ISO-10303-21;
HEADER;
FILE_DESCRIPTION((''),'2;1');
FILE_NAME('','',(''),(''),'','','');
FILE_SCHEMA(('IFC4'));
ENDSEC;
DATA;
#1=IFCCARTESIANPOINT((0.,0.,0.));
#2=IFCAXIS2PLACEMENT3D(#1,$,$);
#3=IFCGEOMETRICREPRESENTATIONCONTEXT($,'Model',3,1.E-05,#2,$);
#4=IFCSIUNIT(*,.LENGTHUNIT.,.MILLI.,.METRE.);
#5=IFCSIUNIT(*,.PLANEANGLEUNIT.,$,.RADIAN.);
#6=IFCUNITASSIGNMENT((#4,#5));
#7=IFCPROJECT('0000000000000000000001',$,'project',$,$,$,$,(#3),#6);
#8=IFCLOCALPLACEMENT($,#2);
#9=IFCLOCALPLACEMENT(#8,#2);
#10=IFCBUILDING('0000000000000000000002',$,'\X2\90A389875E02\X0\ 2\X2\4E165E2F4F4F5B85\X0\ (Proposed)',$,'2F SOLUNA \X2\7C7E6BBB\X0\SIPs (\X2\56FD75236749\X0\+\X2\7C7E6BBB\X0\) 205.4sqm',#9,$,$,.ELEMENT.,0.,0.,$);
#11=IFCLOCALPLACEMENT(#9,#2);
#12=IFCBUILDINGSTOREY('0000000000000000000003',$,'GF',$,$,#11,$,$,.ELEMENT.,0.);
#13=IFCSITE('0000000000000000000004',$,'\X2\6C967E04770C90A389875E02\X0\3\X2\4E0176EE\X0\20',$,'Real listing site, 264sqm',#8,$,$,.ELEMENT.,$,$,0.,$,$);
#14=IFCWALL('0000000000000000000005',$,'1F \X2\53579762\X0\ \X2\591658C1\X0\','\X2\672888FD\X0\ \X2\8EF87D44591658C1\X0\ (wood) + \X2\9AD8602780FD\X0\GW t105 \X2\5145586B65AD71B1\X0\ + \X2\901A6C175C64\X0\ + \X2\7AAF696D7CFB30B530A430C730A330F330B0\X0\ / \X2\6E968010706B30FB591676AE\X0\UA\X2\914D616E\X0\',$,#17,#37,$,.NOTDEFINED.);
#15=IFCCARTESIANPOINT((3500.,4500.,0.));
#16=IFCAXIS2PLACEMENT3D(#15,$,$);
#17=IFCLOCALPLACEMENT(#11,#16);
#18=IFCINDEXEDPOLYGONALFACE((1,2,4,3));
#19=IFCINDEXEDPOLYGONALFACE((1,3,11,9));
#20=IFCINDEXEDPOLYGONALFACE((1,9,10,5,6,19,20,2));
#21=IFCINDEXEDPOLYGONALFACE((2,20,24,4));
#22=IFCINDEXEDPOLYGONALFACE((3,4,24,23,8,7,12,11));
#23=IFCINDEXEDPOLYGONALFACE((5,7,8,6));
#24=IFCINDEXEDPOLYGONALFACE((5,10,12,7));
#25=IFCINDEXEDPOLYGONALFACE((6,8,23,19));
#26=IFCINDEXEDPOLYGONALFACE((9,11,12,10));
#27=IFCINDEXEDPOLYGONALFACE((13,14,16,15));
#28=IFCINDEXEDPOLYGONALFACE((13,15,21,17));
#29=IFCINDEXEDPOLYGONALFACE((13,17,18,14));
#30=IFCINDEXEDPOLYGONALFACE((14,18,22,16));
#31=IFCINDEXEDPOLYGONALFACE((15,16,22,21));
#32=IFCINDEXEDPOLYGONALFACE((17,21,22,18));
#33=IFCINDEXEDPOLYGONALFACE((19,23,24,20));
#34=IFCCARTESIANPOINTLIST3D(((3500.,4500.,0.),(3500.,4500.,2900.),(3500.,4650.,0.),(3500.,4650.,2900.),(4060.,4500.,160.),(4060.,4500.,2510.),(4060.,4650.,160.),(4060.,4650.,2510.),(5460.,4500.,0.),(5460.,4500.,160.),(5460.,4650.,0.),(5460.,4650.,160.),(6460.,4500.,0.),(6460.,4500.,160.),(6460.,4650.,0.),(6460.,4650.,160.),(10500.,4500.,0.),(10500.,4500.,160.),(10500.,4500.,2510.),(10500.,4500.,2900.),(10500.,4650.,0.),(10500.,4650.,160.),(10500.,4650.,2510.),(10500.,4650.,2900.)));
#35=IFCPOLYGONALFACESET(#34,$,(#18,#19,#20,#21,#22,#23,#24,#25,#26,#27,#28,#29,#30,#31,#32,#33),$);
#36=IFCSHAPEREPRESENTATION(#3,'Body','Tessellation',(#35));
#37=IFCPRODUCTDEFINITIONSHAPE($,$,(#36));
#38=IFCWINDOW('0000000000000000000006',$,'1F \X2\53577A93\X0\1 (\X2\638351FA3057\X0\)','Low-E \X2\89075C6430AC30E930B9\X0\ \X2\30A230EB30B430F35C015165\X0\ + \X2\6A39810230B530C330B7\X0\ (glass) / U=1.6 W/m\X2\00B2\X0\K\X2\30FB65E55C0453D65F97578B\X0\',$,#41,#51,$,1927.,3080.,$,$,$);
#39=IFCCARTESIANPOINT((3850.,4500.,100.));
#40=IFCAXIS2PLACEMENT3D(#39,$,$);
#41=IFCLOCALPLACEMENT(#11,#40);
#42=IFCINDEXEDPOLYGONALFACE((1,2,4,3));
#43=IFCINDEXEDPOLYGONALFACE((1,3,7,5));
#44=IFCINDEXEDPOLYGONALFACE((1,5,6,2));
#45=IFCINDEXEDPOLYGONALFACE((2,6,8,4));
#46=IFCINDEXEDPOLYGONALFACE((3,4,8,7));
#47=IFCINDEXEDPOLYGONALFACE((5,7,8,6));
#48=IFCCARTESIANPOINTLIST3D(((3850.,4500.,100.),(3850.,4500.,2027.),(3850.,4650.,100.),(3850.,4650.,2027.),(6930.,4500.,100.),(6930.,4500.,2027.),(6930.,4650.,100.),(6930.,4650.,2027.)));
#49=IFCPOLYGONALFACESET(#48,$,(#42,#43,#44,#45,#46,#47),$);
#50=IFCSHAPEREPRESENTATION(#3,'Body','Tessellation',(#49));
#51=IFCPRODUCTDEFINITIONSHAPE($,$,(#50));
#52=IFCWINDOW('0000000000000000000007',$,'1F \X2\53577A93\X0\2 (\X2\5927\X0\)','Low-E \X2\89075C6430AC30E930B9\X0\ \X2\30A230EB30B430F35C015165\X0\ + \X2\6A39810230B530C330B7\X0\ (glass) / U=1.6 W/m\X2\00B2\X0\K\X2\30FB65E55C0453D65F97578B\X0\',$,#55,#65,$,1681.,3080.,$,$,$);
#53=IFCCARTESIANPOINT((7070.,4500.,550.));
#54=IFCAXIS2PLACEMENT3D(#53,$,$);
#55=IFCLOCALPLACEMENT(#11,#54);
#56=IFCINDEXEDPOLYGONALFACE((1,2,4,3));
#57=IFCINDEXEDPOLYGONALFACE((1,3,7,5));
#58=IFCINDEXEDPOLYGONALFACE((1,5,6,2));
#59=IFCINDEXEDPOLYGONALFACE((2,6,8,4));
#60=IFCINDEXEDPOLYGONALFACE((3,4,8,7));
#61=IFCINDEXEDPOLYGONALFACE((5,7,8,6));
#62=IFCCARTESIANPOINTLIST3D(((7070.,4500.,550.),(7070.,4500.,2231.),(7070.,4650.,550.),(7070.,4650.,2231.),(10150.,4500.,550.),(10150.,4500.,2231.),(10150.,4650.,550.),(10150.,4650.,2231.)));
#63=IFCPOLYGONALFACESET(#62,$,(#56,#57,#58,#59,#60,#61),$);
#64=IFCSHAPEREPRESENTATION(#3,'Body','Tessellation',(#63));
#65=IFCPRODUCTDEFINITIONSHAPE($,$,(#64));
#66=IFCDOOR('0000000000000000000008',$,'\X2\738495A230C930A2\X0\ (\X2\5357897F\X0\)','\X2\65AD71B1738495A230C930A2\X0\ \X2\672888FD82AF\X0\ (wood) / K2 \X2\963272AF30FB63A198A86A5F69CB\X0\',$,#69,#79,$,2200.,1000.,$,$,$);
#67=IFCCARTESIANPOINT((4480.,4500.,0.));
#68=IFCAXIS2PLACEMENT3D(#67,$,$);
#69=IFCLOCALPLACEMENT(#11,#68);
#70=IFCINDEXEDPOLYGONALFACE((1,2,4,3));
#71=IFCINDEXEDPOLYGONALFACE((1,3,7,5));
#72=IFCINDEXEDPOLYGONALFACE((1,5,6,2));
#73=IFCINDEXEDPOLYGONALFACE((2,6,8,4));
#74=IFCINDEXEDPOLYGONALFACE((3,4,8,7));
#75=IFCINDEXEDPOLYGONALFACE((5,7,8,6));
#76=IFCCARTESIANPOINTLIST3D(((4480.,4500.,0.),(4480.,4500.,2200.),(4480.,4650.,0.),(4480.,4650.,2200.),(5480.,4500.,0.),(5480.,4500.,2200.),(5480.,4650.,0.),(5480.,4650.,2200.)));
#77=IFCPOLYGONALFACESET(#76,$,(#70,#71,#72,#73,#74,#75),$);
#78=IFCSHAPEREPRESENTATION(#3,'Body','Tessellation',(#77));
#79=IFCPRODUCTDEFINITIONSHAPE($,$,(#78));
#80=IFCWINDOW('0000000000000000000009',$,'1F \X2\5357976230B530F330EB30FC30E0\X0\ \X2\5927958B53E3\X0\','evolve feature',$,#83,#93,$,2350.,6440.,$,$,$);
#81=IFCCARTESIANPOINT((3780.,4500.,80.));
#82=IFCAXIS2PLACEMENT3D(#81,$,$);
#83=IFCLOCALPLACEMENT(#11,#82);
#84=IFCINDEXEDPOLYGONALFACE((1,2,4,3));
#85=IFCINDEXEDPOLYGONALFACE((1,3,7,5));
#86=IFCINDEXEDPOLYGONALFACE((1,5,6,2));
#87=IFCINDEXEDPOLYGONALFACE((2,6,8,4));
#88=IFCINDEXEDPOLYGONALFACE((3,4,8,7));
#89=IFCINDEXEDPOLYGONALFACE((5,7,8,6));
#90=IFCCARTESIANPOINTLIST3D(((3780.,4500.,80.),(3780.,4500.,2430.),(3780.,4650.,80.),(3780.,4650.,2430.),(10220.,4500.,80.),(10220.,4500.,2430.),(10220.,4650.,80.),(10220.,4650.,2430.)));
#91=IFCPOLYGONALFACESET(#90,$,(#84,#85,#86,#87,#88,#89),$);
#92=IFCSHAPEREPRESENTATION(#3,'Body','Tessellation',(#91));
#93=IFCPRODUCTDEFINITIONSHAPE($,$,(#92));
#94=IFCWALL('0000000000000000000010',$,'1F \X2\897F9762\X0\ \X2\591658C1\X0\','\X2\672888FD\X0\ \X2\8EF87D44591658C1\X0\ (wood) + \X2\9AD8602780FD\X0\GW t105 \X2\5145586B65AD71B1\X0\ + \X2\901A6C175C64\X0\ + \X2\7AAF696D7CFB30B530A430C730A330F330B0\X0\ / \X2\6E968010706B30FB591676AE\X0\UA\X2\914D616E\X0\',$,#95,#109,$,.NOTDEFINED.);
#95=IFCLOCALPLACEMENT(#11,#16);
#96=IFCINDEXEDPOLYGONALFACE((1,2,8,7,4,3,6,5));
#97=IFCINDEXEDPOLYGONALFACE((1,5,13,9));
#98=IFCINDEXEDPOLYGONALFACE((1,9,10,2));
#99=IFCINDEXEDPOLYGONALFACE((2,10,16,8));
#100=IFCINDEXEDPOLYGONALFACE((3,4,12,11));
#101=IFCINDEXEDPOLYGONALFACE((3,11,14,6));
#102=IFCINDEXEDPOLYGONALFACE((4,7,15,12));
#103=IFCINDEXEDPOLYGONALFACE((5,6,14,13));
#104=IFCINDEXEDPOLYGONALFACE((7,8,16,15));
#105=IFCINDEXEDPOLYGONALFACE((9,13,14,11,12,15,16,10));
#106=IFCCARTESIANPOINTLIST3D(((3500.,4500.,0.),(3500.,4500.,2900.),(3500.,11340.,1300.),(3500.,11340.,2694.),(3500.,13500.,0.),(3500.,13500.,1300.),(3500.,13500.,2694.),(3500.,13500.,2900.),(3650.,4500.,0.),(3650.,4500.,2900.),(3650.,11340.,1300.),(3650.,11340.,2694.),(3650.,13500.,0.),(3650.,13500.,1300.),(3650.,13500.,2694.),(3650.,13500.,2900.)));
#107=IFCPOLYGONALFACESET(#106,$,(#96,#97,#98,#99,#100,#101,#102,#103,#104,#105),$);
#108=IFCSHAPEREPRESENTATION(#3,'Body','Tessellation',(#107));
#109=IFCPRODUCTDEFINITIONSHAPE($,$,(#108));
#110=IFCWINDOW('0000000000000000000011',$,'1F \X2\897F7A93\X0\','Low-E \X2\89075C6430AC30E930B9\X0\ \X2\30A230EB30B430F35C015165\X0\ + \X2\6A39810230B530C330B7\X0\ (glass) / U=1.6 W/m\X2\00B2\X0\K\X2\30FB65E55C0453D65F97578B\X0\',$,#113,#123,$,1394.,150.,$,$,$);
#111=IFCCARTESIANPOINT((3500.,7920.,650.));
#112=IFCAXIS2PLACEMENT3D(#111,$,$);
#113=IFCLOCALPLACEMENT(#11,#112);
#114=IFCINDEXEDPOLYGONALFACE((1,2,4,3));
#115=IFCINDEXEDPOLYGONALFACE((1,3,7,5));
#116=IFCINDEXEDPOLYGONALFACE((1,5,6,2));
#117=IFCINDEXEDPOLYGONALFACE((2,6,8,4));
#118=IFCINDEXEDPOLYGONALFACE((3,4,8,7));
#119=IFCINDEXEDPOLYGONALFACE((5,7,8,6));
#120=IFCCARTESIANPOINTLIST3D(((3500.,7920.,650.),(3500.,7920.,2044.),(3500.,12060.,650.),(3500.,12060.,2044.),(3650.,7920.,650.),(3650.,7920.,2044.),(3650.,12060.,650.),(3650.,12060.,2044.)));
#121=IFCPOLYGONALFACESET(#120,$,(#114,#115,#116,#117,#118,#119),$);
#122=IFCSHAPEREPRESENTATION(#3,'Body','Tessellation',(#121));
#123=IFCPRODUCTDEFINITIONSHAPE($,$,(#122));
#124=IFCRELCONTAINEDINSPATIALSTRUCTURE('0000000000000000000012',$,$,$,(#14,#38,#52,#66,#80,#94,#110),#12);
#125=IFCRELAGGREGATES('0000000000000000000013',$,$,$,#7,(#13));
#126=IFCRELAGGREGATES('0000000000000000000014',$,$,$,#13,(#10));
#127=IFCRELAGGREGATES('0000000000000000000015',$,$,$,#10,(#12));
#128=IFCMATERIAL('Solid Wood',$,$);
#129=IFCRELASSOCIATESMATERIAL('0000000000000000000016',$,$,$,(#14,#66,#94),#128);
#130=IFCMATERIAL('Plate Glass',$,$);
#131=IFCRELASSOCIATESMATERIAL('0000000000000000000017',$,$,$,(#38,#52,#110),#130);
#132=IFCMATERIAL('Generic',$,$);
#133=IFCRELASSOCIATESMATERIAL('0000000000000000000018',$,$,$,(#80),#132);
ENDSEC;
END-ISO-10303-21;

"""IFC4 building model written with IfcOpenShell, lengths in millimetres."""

from ifc_helpers import new_model, si_unit, frame, frame_2d, origin, place, context, project, spatial, rectangle, extrude, material, element, fill, save


model = new_model("IFC4")

# Units and contexts
model_context = context("Model", 3, precision=1e-05, world=origin())
ifc_project = project(units=[si_unit("LENGTHUNIT", "METRE", prefix="MILLI"), si_unit("PLANEANGLEUNIT", "RADIAN")], contexts=[model_context])

# Site, building, storey
site_placement = place(None, origin())
site = spatial("IfcSite", under=ifc_project, at=site_placement, Name="沖縄県那覇市3丁目20", ObjectType="Real listing site, 264sqm", CompositionType="ELEMENT", RefElevation=0.0)
building_placement = place(site_placement, origin())
building = spatial("IfcBuilding", under=site, at=building_placement, Name="那覇市 2世帯住宅 (Proposed)", ObjectType="2F SOLUNA 籾殻SIPs (国産杉+籾殻) 205.4sqm", CompositionType="ELEMENT", ElevationOfRefHeight=0.0, ElevationOfTerrain=0.0)
storey_placement = place(building_placement, origin())
storey = spatial("IfcBuildingStorey", under=building, at=storey_placement, Name="GF", CompositionType="ELEMENT", Elevation=0.0)

# Shared definitions
ifc_material_1 = material(Name="Solid Wood")

# Wall, openings, windows, door
wall_1_placement = place(storey_placement, frame((3500.0, 4500.0, 0.0)))
wall_1 = element("IfcWall", 1, at=wall_1_placement, inside=storey, material=ifc_material_1, Name="1F 南面 外壁", Description="木製 軸組外壁 (wood) + 高性能GW t105 充填断熱 + 通気層 + 窯業系サイディング / 準耐火・外皮UA配慮", PredefinedType="NOTDEFINED", context=model_context, shape_type="SweptSolid", body=[
    extrude(rectangle(XDim=7000.0, YDim=150.0, at=frame_2d((3500.0, 75.0))), frame((3500.0, 4500.0, 0.0)), (0.0, 0.0, 1.0), 2900.0),
])
opening_1_placement = place(storey_placement, frame((3850.0, 4500.0, 100.0)))
opening_1 = element("IfcOpeningElement", 2, at=opening_1_placement, cuts=wall_1, PredefinedType="NOTDEFINED", context=model_context, shape_type="SweptSolid", body=[
    extrude(rectangle(XDim=3080.0, YDim=150.0, at=frame_2d((1540.0, 75.0))), frame((3850.0, 4500.0, 100.0)), (0.0, 0.0, 1.0), 1927.0),
])
opening_2_placement = place(storey_placement, frame((7070.0, 4500.0, 550.0)))
opening_2 = element("IfcOpeningElement", 3, at=opening_2_placement, cuts=wall_1, PredefinedType="NOTDEFINED", context=model_context, shape_type="SweptSolid", body=[
    extrude(rectangle(XDim=3080.0, YDim=150.0, at=frame_2d((1540.0, 75.0))), frame((7070.0, 4500.0, 550.0)), (0.0, 0.0, 1.0), 1681.0),
])
opening_3_placement = place(storey_placement, frame((4480.0, 4500.0, 0.0)))
opening_3 = element("IfcOpeningElement", 4, at=opening_3_placement, cuts=wall_1, PredefinedType="NOTDEFINED", context=model_context, shape_type="SweptSolid", body=[
    extrude(rectangle(XDim=1000.0, YDim=150.0, at=frame_2d((500.0, 75.0))), frame((4480.0, 4500.0, 0.0)), (0.0, 0.0, 1.0), 2200.0),
])
opening_4_placement = place(storey_placement, frame((3780.0, 4500.0, 80.0)))
opening_4 = element("IfcOpeningElement", 5, at=opening_4_placement, cuts=wall_1, PredefinedType="NOTDEFINED", context=model_context, shape_type="SweptSolid", body=[
    extrude(rectangle(XDim=6440.0, YDim=150.0, at=frame_2d((3220.0, 75.0))), frame((3780.0, 4500.0, 80.0)), (0.0, 0.0, 1.0), 2350.0),
])
ifc_material_2 = material(Name="Plate Glass")
window_1_placement = place(storey_placement, frame((3850.0, 4500.0, 100.0)))
window_1 = element("IfcWindow", 6, at=window_1_placement, inside=storey, material=ifc_material_2, Name="1F 南窓1 (掃出し)", Description="Low-E 複層ガラス アルゴン封入 + 樹脂サッシ (glass) / U=1.6 W/m²K・日射取得型", OverallHeight=1927.0, OverallWidth=3080.0, context=model_context, shape_type="SweptSolid", body=[
    extrude(rectangle(XDim=3080.0, YDim=150.0, at=frame_2d((1540.0, 75.0))), frame((3850.0, 4500.0, 100.0)), (0.0, 0.0, 1.0), 1927.0),
])
fill(opening_1, window_1)
window_2_placement = place(storey_placement, frame((7070.0, 4500.0, 550.0)))
window_2 = element("IfcWindow", 7, at=window_2_placement, inside=storey, material=ifc_material_2, Name="1F 南窓2 (大)", Description="Low-E 複層ガラス アルゴン封入 + 樹脂サッシ (glass) / U=1.6 W/m²K・日射取得型", OverallHeight=1681.0, OverallWidth=3080.0, context=model_context, shape_type="SweptSolid", body=[
    extrude(rectangle(XDim=3080.0, YDim=150.0, at=frame_2d((1540.0, 75.0))), frame((7070.0, 4500.0, 550.0)), (0.0, 0.0, 1.0), 1681.0),
])
fill(opening_2, window_2)
door_placement = place(storey_placement, frame((4480.0, 4500.0, 0.0)))
door = element("IfcDoor", 8, at=door_placement, inside=storey, material=ifc_material_1, Name="玄関ドア (南西)", Description="断熱玄関ドア 木製芯 (wood) / K2 防犯・採風機構", OverallHeight=2200.0, OverallWidth=1000.0, context=model_context, shape_type="SweptSolid", body=[
    extrude(rectangle(XDim=1000.0, YDim=150.0, at=frame_2d((500.0, 75.0))), frame((4480.0, 4500.0, 0.0)), (0.0, 0.0, 1.0), 2200.0),
])
fill(opening_3, door)
ifc_material_3 = material(Name="Generic")
window_3_placement = place(storey_placement, frame((3780.0, 4500.0, 80.0)))
window_3 = element("IfcWindow", 9, at=window_3_placement, inside=storey, material=ifc_material_3, Name="1F 南面サンルーム 大開口", Description="evolve feature", OverallHeight=2350.0, OverallWidth=6440.0, context=model_context, shape_type="SweptSolid", body=[
    extrude(rectangle(XDim=6440.0, YDim=150.0, at=frame_2d((3220.0, 75.0))), frame((3780.0, 4500.0, 80.0)), (0.0, 0.0, 1.0), 2350.0),
])
fill(opening_4, window_3)

# Wall, opening, window
wall_2_placement = place(storey_placement, frame((3500.0, 4500.0, 0.0)))
wall_2 = element("IfcWall", 10, at=wall_2_placement, inside=storey, material=ifc_material_1, Name="1F 西面 外壁", Description="木製 軸組外壁 (wood) + 高性能GW t105 充填断熱 + 通気層 + 窯業系サイディング / 準耐火・外皮UA配慮", PredefinedType="NOTDEFINED", context=model_context, shape_type="SweptSolid", body=[
    extrude(rectangle(XDim=150.0, YDim=9000.0, at=frame_2d((75.0, 4500.0))), frame((3500.0, 4500.0, 0.0)), (0.0, 0.0, 1.0), 2900.0),
])
opening_5_placement = place(storey_placement, frame((3500.0, 7920.0, 650.0)))
opening_5 = element("IfcOpeningElement", 11, at=opening_5_placement, cuts=wall_2, PredefinedType="NOTDEFINED", context=model_context, shape_type="SweptSolid", body=[
    extrude(rectangle(XDim=150.0, YDim=4140.0, at=frame_2d((75.0, 2070.0))), frame((3500.0, 7920.0, 650.0)), (0.0, 0.0, 1.0), 1394.0),
])
window_4_placement = place(storey_placement, frame((3500.0, 7920.0, 650.0)))
window_4 = element("IfcWindow", 12, at=window_4_placement, inside=storey, material=ifc_material_2, Name="1F 西窓", Description="Low-E 複層ガラス アルゴン封入 + 樹脂サッシ (glass) / U=1.6 W/m²K・日射取得型", OverallHeight=1394.0, OverallWidth=150.0, context=model_context, shape_type="SweptSolid", body=[
    extrude(rectangle(XDim=150.0, YDim=4140.0, at=frame_2d((75.0, 2070.0))), frame((3500.0, 7920.0, 650.0)), (0.0, 0.0, 1.0), 1394.0),
])
fill(opening_5, window_4)

save(model, "model.ifc")
